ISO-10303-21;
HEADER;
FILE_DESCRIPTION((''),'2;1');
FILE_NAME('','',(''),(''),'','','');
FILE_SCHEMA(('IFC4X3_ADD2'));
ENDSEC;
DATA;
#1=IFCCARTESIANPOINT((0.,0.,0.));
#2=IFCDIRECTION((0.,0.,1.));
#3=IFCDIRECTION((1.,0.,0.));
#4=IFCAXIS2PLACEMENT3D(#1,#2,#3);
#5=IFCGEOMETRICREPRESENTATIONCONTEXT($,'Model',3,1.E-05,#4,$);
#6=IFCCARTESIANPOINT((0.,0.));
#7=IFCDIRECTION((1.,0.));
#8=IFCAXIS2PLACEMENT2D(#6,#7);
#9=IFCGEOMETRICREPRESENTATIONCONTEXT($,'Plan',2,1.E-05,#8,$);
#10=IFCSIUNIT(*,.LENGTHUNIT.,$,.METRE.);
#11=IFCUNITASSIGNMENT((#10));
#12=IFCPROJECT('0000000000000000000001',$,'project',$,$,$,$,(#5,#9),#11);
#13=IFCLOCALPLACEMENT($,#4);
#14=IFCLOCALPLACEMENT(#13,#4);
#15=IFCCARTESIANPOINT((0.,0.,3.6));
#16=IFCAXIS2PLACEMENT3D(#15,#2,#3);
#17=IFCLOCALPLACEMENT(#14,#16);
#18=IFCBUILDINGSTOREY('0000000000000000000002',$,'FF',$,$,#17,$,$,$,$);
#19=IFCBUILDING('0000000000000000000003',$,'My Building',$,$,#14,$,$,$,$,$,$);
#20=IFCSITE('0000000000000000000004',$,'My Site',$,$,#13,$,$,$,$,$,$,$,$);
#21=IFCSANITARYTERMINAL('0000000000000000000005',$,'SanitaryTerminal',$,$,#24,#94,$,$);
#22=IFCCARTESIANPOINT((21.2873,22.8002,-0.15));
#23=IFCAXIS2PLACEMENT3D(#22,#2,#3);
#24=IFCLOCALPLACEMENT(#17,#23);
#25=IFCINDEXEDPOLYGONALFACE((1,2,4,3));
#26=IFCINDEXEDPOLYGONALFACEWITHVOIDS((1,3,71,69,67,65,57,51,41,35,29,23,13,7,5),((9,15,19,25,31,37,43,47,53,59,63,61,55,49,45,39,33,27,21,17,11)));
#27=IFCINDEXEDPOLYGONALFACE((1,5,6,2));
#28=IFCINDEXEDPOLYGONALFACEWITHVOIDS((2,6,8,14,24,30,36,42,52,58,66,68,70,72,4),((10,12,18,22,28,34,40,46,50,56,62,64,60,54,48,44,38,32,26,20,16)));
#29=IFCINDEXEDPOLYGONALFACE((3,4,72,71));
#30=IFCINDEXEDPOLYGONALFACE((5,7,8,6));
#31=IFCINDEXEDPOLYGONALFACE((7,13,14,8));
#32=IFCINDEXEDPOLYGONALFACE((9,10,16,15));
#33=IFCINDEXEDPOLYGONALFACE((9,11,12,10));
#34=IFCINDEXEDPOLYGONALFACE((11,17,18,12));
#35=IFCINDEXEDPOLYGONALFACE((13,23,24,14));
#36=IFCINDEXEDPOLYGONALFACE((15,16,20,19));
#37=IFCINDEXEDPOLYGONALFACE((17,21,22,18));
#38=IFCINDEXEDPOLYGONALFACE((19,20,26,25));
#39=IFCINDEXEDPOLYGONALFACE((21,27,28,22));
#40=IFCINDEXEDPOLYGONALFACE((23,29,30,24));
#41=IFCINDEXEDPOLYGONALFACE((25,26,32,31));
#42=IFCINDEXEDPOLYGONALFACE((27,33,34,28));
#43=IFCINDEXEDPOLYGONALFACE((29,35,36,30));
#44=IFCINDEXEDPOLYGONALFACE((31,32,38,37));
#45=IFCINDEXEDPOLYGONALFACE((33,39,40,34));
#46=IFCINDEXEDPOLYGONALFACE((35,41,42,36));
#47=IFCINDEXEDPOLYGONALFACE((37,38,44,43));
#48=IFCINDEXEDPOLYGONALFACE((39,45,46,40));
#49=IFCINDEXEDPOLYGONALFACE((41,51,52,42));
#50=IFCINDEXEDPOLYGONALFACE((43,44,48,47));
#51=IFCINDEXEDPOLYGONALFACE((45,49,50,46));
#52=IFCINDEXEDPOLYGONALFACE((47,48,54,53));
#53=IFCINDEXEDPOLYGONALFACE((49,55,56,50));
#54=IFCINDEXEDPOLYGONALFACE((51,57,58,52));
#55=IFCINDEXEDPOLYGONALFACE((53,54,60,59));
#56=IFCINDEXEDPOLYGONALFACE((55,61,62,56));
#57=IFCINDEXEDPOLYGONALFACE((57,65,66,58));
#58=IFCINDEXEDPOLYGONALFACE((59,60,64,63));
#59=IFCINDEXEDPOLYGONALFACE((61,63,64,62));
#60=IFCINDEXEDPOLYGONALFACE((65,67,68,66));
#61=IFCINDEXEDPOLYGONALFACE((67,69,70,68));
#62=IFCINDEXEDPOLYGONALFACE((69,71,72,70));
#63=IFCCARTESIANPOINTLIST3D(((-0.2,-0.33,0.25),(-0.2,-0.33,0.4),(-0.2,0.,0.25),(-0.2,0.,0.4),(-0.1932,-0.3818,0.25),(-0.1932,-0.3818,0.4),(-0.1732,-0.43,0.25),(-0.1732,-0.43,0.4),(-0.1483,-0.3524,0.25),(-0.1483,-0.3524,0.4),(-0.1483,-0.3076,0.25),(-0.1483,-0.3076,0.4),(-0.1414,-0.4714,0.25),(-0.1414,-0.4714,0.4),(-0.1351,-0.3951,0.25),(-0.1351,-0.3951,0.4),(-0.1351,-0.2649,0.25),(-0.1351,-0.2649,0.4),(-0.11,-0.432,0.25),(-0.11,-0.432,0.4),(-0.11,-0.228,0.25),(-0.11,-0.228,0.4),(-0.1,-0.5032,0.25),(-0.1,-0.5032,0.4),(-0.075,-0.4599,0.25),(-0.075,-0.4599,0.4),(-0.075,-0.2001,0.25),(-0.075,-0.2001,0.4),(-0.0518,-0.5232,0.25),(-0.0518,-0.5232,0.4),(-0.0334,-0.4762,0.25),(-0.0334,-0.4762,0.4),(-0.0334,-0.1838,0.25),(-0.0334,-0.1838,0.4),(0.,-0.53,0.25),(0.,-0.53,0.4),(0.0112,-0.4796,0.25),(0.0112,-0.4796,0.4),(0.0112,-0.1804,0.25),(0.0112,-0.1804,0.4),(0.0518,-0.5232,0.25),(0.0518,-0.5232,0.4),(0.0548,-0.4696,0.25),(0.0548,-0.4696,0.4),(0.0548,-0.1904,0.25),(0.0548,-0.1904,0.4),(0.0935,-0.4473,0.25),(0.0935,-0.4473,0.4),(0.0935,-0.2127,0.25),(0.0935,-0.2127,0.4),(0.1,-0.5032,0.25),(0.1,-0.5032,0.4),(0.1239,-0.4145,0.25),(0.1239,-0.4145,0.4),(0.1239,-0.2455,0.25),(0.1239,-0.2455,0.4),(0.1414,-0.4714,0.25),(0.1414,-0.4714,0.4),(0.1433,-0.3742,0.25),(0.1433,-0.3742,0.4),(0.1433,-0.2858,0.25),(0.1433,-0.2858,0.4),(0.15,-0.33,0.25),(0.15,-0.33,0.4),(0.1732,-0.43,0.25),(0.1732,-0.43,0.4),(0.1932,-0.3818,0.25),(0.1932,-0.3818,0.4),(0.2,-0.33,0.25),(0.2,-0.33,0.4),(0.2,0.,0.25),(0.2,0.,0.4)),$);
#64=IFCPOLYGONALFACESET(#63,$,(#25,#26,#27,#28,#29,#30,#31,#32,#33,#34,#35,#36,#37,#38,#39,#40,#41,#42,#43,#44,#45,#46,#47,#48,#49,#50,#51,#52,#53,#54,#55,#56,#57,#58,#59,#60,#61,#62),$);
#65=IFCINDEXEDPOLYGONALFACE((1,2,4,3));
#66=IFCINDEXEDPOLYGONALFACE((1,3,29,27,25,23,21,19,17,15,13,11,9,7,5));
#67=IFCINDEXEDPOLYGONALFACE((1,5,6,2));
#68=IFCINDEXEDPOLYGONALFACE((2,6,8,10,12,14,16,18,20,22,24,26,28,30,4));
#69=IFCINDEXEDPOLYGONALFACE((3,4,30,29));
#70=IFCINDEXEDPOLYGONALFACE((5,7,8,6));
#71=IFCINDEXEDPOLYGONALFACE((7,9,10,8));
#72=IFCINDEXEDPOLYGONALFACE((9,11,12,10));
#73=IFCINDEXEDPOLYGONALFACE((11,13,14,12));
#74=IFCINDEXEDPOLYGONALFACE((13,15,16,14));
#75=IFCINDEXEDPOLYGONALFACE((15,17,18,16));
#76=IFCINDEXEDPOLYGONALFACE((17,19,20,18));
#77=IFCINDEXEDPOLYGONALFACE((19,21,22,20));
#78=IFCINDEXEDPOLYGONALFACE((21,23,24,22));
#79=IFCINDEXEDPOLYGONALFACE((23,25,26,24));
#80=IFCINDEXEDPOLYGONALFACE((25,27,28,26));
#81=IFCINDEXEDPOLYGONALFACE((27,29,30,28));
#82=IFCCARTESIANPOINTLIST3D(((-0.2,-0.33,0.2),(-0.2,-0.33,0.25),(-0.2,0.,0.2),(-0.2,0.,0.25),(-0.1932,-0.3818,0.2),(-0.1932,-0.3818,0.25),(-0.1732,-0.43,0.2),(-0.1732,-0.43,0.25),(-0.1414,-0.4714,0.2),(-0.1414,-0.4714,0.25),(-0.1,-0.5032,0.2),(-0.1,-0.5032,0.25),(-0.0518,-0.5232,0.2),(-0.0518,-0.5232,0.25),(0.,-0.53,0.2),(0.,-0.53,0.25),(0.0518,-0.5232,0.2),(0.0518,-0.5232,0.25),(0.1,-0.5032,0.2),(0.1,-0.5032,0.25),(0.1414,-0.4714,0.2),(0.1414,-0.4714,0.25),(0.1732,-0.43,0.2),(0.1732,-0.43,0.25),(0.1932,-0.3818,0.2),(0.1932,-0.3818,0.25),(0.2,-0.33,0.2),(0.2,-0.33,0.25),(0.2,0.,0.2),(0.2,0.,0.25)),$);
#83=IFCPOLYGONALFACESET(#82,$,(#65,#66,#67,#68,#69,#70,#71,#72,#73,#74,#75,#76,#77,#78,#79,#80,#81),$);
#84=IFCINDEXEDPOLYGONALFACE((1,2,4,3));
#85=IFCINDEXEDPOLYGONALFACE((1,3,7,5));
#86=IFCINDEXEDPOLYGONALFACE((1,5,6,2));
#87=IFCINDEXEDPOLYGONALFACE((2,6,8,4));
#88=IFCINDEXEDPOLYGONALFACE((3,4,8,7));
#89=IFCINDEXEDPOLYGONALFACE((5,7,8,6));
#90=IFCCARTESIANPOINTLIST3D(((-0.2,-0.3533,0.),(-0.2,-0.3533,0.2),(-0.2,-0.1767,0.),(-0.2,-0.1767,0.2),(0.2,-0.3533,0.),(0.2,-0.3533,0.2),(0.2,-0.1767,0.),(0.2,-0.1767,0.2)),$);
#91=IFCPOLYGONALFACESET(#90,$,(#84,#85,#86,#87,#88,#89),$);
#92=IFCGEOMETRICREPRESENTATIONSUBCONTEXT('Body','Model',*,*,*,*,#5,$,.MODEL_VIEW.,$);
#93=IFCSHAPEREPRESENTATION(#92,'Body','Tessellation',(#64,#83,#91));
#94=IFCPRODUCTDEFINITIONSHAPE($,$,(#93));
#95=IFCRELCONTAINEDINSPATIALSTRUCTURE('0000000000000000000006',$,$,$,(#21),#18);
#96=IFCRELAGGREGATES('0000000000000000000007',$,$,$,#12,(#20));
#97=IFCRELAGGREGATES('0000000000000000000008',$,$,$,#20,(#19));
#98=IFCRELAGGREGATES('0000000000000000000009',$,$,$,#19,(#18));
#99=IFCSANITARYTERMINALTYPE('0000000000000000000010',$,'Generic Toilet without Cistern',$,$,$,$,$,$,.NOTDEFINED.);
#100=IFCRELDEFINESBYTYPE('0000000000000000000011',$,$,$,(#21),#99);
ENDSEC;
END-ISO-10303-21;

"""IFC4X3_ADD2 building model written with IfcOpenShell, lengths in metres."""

from ifc_helpers import new_model, entity, si_unit, frame, frame_2d, origin_with_axes, origin_2d_with_axis, place, context, subcontext, project, spatial, line, arc, indexed_curve, circle_curve, outline, extrude, shape, source, transform, mapped, type_object, type_shapes, element, save


model = new_model("IFC4X3_ADD2")

# Units and contexts
model_context = context("Model", 3, precision=1e-05, world=origin_with_axes())
plan_context = context("Plan", 2, precision=1e-05, world=origin_2d_with_axis())
body_context_1 = subcontext(model_context, "Body", "Model", "MODEL_VIEW")
body_context_2 = subcontext(plan_context, "Body", "Plan", "PLAN_VIEW")
ifc_project = project(units=[si_unit("LENGTHUNIT", "METRE")], contexts=[model_context, plan_context])

# Site, building, storey
site_placement = place(None, origin_with_axes())
site = spatial("IfcSite", under=ifc_project, at=site_placement, Name="My Site")
building_placement = place(site_placement, origin_with_axes())
building = spatial("IfcBuilding", under=site, at=building_placement, Name="My Building")
storey_placement = place(building_placement, frame((0.0, 0.0, 3.6), z_axis=(0.0, 0.0, 1.0), x_axis=(1.0, 0.0, 0.0)))
storey = spatial("IfcBuildingStorey", under=building, at=storey_placement, Name="FF")

# Sanitary terminal
sanitary_terminal_type_1 = type_object("IfcSanitaryTerminalType", Name="Generic Toilet without Cistern", PredefinedType="NOTDEFINED")
shared_shape_1 = source(origin_with_axes(), body_context_1, "Body", "SweptSolid", [
    extrude(outline(indexed_curve([(-0.2, 0.0), (0.2, 0.0), (0.2, -0.33), (0.1414, -0.4714), (0.0, -0.53), (-0.1414, -0.4714), (-0.2, -0.33)], segments=[line(1, 2), line(2, 3), arc(3, 4, 5), arc(5, 6, 7), line(7, 1)]), holes=[circle_curve(frame_2d((0.0, -0.33)), 0.15)]), frame((0.0, 0.0, 0.25), z_axis=(0.0, 0.0, 1.0), x_axis=(1.0, 0.0, 0.0)), (0.0, 0.0, 1.0), 0.15),
    extrude(outline(indexed_curve([(-0.2, 0.0), (0.2, 0.0), (0.2, -0.33), (0.1414, -0.4714), (0.0, -0.53), (-0.1414, -0.4714), (-0.2, -0.33)], segments=[line(1, 2), line(2, 3), arc(3, 4, 5), arc(5, 6, 7), line(7, 1)])), frame((0.0, 0.0, 0.2), z_axis=(0.0, 0.0, 1.0), x_axis=(1.0, 0.0, 0.0)), (0.0, 0.0, 1.0), 0.05),
    extrude(outline(indexed_curve([(-0.2, -0.1767), (0.2, -0.1767), (0.2, -0.3533), (-0.2, -0.3533)], segments=[line(1, 2, 3, 4, 1)])), origin_with_axes(), (0.0, 0.0, 1.0), 0.2),
])
shared_shape_2 = source(origin_with_axes(), body_context_2, "Body", "GeometricSet", [
    entity("IfcGeometricCurveSet", [entity("IfcIndexedPolyCurve", entity("IfcCartesianPointList2D", [[-0.1068, -0.124], [-0.0957, -0.1129], [-0.0804, -0.1088], [0.0804, -0.1088], [0.0957, -0.1129], [0.1068, -0.124], [0.1109, -0.1393], [0.1109, -0.3476], [0.1025, -0.3926], [0.0784, -0.4308], [0.0424, -0.4563], [0.0, -0.4652], [-0.0424, -0.4563], [-0.0784, -0.4308], [-0.1025, -0.3926], [-0.1109, -0.3476], [-0.1109, -0.1393]]), [entity("IfcLineIndex", [1, 2, 3, 4, 5, 6, 7, 8, 9, 10, 11, 12, 13, 14, 15, 16, 17, 1])]), entity("IfcIndexedPolyCurve", entity("IfcCartesianPointList2D", [[-0.1962, -0.2314], [-0.1848, -0.301], [-0.1764, -0.3339], [-0.1663, -0.3651], [-0.1546, -0.3944], [-0.1414, -0.4213], [-0.1269, -0.4458], [-0.1111, -0.4675], [-0.0943, -0.4862], [-0.0765, -0.5018], [-0.0581, -0.514], [-0.039, -0.5229], [-0.0196, -0.5282], [0.0, -0.53], [0.0196, -0.5282], [0.039, -0.5229], [0.0581, -0.514], [0.0765, -0.5018], [0.0943, -0.4862], [0.1111, -0.4675], [0.1269, -0.4458], [0.1414, -0.4213], [0.1546, -0.3944], [0.1663, -0.3651], [0.1764, -0.3339], [0.1848, -0.301], [0.1962, -0.2314], [0.2, -0.159], [0.1872, 0.0], [-0.1872, 0.0], [-0.2, -0.159]]), [entity("IfcLineIndex", [1, 2, 3, 4, 5, 6, 7, 8, 9, 10, 11, 12, 13, 14, 15, 16, 17, 18, 19, 20, 21, 22, 23, 24, 25, 26, 27, 28, 29, 30, 31, 1])])]),
])
type_shapes(sanitary_terminal_type_1, [shared_shape_1, shared_shape_2])
sanitary_terminal_1_placement = place(storey_placement, frame((21.2873, 22.8002, -0.15), z_axis=(0.0, 0.0, 1.0), x_axis=(1.0, 0.0, 0.0)))
element("IfcSanitaryTerminal", 1, at=sanitary_terminal_1_placement, inside=storey, type_object=sanitary_terminal_type_1, Name="SanitaryTerminal", shapes=[
    shape(body_context_1, "Body", "MappedRepresentation", [mapped(shared_shape_1, transform((0.0, 0.0, 0.0), x_axis=(1.0, 0.0, 0.0), y_axis=(0.0, 1.0, 0.0), z_axis=(0.0, 0.0, 1.0), scale=1.0))]),
    shape(body_context_2, "Body", "MappedRepresentation", [mapped(shared_shape_2, transform((0.0, 0.0, 0.0), x_axis=(1.0, 0.0, 0.0), y_axis=(0.0, 1.0, 0.0), z_axis=(0.0, 0.0, 1.0), scale=1.0))]),
])

save(model, "model.ifc")
